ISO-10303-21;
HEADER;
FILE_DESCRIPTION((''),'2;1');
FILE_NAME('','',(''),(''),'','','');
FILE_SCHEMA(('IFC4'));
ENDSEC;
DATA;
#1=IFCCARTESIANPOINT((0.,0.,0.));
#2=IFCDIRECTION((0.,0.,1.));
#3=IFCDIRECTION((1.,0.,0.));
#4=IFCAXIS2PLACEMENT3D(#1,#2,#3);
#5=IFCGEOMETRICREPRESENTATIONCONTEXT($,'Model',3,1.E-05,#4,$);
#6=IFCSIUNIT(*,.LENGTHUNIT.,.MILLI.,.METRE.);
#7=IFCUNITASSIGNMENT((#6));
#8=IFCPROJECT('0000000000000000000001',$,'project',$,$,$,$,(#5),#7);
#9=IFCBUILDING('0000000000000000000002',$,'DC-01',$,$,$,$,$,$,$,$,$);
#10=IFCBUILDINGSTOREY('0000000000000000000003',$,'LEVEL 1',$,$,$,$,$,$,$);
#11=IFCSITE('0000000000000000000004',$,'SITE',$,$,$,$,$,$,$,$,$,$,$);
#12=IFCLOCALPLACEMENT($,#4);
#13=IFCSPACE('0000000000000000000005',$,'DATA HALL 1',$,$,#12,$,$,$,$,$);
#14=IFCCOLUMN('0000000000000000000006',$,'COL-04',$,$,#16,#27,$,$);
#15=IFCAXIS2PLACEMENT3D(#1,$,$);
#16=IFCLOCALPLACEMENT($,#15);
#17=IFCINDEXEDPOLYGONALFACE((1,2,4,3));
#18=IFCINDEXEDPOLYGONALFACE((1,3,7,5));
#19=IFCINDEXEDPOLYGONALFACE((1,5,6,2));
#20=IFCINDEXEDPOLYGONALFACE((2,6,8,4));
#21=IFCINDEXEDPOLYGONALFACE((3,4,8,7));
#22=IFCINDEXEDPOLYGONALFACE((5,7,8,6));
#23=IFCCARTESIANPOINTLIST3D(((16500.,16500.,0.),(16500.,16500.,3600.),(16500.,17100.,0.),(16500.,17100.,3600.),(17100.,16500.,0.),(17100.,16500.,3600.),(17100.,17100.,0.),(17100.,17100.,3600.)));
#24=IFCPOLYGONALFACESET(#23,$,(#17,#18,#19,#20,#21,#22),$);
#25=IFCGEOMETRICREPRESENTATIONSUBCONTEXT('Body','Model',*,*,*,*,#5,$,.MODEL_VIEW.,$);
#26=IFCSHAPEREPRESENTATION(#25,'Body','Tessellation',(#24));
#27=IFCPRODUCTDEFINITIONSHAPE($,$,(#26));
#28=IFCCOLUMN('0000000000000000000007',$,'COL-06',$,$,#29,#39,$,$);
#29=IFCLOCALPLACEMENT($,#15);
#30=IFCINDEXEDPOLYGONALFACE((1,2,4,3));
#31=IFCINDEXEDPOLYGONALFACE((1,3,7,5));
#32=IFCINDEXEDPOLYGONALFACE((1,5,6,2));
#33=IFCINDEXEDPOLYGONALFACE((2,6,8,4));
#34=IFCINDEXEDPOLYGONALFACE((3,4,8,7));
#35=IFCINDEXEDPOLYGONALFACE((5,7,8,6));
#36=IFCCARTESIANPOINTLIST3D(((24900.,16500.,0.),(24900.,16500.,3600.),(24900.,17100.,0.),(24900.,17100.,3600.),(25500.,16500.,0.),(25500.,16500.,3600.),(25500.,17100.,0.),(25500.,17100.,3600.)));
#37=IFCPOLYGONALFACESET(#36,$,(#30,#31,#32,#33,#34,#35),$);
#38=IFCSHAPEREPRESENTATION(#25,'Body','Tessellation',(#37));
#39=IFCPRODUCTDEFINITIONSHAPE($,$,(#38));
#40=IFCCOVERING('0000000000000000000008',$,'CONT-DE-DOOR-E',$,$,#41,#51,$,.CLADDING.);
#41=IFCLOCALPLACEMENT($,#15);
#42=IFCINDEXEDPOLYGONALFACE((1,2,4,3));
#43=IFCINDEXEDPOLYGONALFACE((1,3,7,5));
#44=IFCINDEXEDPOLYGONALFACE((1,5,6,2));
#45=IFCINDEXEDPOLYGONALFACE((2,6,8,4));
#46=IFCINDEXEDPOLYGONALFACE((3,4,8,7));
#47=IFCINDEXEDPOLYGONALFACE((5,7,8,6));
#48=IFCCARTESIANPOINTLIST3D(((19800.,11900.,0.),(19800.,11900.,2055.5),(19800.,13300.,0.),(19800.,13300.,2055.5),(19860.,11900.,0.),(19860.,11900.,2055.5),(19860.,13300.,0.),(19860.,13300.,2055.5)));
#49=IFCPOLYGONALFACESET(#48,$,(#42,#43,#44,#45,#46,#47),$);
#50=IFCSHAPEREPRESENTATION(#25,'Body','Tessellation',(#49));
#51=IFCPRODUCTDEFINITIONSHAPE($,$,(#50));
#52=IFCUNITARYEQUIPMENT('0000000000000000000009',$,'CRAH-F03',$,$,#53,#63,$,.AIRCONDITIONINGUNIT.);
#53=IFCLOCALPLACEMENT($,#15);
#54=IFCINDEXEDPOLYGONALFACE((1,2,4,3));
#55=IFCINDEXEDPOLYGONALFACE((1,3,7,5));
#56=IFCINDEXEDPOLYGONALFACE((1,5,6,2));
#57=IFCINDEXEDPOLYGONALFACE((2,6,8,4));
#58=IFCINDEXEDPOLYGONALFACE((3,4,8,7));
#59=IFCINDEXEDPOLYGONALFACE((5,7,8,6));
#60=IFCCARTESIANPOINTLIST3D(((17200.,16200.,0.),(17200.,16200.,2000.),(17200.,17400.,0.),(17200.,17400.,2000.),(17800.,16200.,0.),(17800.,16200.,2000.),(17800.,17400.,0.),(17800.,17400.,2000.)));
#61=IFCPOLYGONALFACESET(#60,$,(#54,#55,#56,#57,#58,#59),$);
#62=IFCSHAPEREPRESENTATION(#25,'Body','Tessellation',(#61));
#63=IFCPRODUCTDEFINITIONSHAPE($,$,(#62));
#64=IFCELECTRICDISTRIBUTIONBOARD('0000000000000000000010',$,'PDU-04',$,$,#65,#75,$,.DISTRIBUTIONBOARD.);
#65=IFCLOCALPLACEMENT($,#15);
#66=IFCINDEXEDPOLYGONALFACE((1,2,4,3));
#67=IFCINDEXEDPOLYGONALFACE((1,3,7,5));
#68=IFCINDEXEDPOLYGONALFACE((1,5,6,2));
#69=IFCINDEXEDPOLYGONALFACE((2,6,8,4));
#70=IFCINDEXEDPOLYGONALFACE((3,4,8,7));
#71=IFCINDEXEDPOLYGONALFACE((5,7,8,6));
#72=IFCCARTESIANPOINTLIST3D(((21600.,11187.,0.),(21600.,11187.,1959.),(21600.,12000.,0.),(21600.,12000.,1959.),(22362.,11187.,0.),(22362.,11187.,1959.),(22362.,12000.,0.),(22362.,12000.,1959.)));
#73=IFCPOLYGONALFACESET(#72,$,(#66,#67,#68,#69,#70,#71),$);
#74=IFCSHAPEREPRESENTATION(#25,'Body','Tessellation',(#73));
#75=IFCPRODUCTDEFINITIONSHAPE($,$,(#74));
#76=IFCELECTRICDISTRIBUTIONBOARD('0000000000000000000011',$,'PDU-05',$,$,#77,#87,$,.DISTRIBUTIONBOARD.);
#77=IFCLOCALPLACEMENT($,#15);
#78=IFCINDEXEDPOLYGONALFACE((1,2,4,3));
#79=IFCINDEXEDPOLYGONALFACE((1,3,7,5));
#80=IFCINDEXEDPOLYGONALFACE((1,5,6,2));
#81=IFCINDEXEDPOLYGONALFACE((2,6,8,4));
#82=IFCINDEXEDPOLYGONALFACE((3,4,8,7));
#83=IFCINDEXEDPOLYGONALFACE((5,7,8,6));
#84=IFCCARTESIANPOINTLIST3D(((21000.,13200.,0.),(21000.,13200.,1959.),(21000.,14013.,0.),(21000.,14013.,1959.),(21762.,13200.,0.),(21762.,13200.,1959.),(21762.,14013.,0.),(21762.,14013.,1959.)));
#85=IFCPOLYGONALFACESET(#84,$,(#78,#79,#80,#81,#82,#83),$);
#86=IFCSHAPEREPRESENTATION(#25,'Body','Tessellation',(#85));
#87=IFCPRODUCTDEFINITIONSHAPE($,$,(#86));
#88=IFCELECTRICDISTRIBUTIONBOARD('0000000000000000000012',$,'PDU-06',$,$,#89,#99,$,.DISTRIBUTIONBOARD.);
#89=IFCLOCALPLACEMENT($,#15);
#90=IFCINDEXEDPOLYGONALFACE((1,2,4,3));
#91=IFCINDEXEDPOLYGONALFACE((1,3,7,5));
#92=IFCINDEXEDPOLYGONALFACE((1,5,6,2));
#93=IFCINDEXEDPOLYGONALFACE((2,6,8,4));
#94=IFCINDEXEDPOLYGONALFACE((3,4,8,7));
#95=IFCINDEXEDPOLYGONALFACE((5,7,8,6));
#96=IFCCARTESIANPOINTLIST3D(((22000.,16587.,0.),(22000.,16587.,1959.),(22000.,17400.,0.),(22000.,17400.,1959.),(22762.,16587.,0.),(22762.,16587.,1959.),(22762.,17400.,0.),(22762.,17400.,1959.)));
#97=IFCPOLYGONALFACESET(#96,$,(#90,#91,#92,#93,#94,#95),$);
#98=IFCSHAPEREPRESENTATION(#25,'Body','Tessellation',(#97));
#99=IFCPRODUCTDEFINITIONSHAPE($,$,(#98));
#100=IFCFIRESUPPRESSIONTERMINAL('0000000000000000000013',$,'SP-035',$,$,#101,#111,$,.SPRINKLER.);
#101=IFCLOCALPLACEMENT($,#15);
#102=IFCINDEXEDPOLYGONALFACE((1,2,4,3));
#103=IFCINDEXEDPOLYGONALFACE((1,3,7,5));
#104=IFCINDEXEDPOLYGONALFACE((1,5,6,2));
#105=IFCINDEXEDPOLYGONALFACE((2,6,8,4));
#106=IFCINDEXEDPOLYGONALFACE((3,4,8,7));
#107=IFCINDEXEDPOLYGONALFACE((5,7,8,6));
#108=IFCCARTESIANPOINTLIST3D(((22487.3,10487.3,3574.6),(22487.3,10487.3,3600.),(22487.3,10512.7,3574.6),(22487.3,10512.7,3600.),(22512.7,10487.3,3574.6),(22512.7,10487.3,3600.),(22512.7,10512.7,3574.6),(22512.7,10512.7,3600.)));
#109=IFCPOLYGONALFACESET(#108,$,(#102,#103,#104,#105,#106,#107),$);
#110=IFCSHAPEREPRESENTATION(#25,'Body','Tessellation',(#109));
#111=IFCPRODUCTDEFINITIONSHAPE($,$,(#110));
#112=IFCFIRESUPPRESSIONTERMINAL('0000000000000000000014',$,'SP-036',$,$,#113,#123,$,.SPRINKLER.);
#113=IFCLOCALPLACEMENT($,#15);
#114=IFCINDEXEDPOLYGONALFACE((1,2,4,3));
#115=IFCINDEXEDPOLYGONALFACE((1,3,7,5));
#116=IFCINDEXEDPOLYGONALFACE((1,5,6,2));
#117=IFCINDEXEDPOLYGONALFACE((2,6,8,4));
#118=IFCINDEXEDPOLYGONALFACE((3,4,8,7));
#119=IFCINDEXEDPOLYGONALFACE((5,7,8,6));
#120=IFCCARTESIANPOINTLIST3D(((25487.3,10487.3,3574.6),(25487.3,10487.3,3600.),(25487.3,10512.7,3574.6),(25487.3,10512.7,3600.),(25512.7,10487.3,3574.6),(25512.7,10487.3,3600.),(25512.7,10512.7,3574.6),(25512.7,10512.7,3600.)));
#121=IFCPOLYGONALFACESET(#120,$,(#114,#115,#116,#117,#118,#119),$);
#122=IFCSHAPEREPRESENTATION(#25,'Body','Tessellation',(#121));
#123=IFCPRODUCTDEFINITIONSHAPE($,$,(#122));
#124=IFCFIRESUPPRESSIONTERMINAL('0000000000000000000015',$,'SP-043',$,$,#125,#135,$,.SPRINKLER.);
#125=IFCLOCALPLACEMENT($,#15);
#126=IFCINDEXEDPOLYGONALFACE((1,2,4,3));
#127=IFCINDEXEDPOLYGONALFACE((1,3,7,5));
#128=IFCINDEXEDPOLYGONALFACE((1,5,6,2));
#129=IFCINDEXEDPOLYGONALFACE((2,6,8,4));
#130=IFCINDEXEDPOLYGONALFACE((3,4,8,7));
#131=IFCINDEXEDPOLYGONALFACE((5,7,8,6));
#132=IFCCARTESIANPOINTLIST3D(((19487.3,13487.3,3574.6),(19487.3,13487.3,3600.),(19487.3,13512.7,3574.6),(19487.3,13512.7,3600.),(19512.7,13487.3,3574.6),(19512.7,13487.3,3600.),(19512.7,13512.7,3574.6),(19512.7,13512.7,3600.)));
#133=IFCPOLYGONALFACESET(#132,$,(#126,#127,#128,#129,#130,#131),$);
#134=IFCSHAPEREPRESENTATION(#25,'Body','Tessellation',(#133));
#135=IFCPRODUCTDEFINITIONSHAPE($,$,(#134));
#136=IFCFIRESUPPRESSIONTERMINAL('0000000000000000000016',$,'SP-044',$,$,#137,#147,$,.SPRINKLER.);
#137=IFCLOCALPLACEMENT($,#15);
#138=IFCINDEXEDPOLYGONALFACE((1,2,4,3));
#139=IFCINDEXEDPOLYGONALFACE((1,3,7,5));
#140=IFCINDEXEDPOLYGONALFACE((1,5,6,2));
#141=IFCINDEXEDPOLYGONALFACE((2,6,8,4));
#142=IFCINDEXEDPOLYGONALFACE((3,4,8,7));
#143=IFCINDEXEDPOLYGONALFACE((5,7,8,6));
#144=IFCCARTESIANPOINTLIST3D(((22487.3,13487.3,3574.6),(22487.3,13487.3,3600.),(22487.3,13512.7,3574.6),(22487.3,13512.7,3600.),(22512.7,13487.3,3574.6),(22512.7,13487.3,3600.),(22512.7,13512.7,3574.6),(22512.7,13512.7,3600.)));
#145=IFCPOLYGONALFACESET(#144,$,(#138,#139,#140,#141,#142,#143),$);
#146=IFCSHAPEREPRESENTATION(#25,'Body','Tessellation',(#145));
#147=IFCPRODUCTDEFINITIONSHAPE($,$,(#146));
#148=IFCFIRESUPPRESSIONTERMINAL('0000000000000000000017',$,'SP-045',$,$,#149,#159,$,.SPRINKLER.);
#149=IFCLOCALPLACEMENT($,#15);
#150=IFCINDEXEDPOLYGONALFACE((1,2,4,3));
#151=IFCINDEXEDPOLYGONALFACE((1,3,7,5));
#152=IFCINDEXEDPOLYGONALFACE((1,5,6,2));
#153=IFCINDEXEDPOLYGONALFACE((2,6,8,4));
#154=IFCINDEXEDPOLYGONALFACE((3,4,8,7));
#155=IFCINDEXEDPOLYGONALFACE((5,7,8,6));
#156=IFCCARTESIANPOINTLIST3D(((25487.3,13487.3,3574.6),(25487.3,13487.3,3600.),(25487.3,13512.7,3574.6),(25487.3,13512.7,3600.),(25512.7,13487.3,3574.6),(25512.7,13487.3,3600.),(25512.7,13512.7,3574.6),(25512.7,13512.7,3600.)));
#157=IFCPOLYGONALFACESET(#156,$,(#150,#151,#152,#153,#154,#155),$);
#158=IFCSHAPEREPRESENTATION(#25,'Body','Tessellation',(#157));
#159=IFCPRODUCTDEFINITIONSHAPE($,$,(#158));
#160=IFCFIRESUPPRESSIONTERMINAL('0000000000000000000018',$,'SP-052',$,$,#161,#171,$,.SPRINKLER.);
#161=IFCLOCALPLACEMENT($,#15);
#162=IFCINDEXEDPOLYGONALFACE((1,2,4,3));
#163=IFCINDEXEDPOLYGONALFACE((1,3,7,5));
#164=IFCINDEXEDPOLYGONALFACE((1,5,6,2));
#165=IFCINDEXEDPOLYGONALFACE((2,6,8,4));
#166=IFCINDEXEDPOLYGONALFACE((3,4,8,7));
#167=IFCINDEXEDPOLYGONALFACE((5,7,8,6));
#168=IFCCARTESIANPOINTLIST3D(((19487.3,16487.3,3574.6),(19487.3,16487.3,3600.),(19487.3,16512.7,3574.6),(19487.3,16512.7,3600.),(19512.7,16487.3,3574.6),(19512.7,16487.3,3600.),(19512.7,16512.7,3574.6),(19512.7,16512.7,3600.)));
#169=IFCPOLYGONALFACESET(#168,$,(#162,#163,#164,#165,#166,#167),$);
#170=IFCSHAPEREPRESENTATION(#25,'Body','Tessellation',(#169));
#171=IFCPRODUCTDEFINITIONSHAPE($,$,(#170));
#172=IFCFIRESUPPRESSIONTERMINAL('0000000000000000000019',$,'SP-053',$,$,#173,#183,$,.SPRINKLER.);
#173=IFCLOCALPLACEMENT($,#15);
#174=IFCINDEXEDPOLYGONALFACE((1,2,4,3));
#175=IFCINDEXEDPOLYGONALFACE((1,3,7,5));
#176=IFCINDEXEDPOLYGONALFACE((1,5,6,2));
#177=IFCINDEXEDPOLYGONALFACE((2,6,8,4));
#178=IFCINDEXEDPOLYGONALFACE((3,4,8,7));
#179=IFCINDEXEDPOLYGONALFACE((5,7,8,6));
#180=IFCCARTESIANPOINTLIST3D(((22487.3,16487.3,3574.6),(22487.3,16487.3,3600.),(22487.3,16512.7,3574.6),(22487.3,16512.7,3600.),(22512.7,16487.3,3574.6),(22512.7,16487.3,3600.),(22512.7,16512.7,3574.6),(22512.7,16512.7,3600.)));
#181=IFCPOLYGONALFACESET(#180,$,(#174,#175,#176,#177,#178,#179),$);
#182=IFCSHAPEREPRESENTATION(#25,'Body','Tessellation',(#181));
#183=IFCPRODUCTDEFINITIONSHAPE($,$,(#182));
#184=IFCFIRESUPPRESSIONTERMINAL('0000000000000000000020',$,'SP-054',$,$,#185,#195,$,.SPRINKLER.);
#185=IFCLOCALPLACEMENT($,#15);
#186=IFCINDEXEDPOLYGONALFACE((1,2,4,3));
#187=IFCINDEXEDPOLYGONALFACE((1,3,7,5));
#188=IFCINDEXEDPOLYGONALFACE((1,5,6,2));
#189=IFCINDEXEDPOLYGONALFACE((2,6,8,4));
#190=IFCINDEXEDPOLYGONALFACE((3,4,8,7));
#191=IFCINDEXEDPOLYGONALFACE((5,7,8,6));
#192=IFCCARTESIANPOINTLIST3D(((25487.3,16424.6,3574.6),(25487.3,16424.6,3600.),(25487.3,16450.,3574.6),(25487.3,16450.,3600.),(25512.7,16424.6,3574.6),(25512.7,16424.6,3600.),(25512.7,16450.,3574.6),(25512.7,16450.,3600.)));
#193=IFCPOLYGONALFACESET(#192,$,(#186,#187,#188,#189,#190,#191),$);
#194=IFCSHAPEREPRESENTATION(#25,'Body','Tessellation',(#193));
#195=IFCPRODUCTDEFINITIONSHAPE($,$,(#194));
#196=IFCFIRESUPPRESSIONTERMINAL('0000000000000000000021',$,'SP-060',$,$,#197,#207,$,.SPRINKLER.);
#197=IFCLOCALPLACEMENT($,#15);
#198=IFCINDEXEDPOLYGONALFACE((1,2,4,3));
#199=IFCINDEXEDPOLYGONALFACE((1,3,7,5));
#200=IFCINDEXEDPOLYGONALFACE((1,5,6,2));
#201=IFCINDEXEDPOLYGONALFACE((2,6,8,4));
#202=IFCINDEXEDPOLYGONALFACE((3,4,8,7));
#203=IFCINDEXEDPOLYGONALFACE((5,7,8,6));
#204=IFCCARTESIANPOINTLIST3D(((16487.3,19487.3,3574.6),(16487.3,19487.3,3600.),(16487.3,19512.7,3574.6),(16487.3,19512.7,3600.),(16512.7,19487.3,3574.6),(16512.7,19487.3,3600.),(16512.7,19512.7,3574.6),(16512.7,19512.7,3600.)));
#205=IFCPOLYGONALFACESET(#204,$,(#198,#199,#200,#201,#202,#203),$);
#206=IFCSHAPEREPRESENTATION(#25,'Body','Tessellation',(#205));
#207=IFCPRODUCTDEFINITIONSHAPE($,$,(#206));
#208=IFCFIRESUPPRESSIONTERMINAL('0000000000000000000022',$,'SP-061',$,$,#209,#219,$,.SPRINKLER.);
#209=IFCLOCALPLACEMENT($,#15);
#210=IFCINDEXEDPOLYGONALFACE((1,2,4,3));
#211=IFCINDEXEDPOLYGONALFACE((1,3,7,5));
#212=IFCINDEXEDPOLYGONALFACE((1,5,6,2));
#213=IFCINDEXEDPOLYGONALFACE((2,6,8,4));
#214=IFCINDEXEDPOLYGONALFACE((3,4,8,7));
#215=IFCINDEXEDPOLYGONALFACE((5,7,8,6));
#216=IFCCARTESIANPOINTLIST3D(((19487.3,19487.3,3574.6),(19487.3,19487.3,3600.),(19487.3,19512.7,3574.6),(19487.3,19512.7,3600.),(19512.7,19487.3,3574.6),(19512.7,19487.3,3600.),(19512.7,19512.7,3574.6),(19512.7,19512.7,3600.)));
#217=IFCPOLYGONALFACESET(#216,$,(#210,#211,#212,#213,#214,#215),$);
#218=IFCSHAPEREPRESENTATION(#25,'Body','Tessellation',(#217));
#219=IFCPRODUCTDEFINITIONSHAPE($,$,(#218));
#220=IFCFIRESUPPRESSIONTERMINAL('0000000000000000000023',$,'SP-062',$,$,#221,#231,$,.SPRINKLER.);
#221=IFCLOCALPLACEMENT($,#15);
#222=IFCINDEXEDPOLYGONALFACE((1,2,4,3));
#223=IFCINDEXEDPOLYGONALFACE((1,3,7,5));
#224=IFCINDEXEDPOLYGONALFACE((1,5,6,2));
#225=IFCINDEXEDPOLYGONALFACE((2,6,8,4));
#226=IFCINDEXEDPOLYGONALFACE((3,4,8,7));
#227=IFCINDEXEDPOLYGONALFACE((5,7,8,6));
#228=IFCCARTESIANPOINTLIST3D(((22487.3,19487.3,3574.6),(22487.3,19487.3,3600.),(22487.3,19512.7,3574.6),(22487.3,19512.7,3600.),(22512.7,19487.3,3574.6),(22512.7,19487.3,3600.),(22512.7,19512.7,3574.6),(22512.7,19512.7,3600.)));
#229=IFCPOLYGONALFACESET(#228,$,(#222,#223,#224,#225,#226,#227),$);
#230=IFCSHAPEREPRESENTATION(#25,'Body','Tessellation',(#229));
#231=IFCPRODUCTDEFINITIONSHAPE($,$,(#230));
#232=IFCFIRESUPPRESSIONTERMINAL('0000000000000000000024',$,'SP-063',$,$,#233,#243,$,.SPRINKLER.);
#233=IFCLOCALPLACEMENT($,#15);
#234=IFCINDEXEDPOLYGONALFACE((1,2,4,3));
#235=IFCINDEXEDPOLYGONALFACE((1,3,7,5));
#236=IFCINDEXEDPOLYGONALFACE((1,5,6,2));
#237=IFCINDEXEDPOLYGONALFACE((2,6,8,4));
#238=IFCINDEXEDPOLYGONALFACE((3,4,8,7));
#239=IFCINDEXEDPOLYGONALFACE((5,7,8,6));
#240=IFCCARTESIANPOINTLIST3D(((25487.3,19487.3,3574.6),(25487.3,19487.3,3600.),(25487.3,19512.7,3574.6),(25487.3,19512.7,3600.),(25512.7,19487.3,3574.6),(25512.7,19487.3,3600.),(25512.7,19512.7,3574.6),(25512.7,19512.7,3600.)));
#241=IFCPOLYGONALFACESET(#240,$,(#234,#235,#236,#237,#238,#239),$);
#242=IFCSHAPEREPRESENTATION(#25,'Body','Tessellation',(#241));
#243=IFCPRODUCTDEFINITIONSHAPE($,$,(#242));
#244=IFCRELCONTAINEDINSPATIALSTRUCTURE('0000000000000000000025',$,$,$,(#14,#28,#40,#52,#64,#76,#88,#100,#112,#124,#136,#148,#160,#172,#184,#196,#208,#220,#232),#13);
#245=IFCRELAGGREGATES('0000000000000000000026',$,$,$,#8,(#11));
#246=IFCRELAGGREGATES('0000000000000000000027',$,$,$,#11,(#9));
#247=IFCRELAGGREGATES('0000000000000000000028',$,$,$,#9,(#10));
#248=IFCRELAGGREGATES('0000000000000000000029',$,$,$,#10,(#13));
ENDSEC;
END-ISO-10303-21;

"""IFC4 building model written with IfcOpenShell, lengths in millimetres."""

from ifc_helpers import new_model, si_unit, frame, origin, origin_with_axes, place, context, subcontext, project, spatial, polyline, outline, extrude, element, save


model = new_model("IFC4")

# Units and contexts
model_context = context("Model", 3, precision=1e-05, world=origin_with_axes())
body_context = subcontext(model_context, "Body", "Model", "MODEL_VIEW")
ifc_project = project(units=[si_unit("LENGTHUNIT", "METRE", prefix="MILLI")], contexts=[model_context])

# Site, building, storey, space
site = spatial("IfcSite", under=ifc_project, Name="SITE")
building = spatial("IfcBuilding", under=site, Name="DC-01")
storey = spatial("IfcBuildingStorey", under=building, Name="LEVEL 1")
space_placement = place(None, origin_with_axes())
space = spatial("IfcSpace", under=storey, at=space_placement, Name="DATA HALL 1")

# Columns
for number, where, z_axis, x_axis, name in (
    (1, (16500.0, 16500.0, 0.0), (0.0, 0.0, 1.0), (1.0, 0.0, 0.0), "COL-04"),
    (2, (24900.0, 16500.0, 0.0), (0.0, 0.0, 1.0), (1.0, 0.0, 0.0), "COL-06"),
):
    element("IfcColumn", number, at=place(space_placement, frame(where, z_axis=z_axis, x_axis=x_axis)), inside=space, Name=name, context=body_context, shape_type="SweptSolid", body=[
        extrude(outline(polyline([(0.0, 0.0), (600.0, 0.0), (600.0, 600.0), (0.0, 600.0), (0.0, 0.0)])), origin(), (0.0, 0.0, 1.0), 3600.0),
    ])

# Covering
covering_placement = place(space_placement, frame((19800.0, 11900.0, 0.0), z_axis=(0.0, 0.0, 1.0), x_axis=(1.0, 0.0, 0.0)))
element("IfcCovering", 3, at=covering_placement, inside=space, Name="CONT-DE-DOOR-E", PredefinedType="CLADDING", context=body_context, shape_type="SweptSolid", body=[
    extrude(outline(polyline([(0.0, 0.0), (60.0, 0.0), (60.0, 1400.0), (0.0, 1400.0), (0.0, 0.0)])), origin(), (0.0, 0.0, 1.0), 2055.5),
])

# Unitary equipment
unitary_equipment_placement = place(space_placement, frame((17200.0, 16200.0, 0.0), z_axis=(0.0, 0.0, 1.0), x_axis=(1.0, 0.0, 0.0)))
element("IfcUnitaryEquipment", 4, at=unitary_equipment_placement, inside=space, Name="CRAH-F03", PredefinedType="AIRCONDITIONINGUNIT", context=body_context, shape_type="SweptSolid", body=[
    extrude(outline(polyline([(0.0, 0.0), (600.0, 0.0), (600.0, 1200.0), (0.0, 1200.0), (0.0, 0.0)])), origin(), (0.0, 0.0, 1.0), 2000.0),
])

# Electric distribution boards
for number, where, z_axis, x_axis, name in (
    (5, (21600.0, 11187.0, 0.0), (0.0, 0.0, 1.0), (1.0, 0.0, 0.0), "PDU-04"),
    (6, (21762.0, 14013.0, 0.0), (0.0, 0.0, 1.0), (-1.0, 0.0, 0.0), "PDU-05"),
    (7, (22000.0, 16587.0, 0.0), (0.0, 0.0, 1.0), (1.0, 0.0, 0.0), "PDU-06"),
):
    element("IfcElectricDistributionBoard", number, at=place(space_placement, frame(where, z_axis=z_axis, x_axis=x_axis)), inside=space, Name=name, PredefinedType="DISTRIBUTIONBOARD", context=body_context, shape_type="SweptSolid", body=[
        extrude(outline(polyline([(0.0, 0.0), (762.0, 0.0), (762.0, 813.0), (0.0, 813.0), (0.0, 0.0)])), origin(), (0.0, 0.0, 1.0), 1959.0),
    ])

# Fire suppression terminals
for number, where, z_axis, x_axis, name in (
    (8, (22487.3, 10487.3, 3574.6), (0.0, 0.0, 1.0), (1.0, 0.0, 0.0), "SP-035"),
    (9, (25487.3, 10487.3, 3574.6), (0.0, 0.0, 1.0), (1.0, 0.0, 0.0), "SP-036"),
    (10, (19487.3, 13487.3, 3574.6), (0.0, 0.0, 1.0), (1.0, 0.0, 0.0), "SP-043"),
    (11, (22487.3, 13487.3, 3574.6), (0.0, 0.0, 1.0), (1.0, 0.0, 0.0), "SP-044"),
    (12, (25487.3, 13487.3, 3574.6), (0.0, 0.0, 1.0), (1.0, 0.0, 0.0), "SP-045"),
    (13, (19487.3, 16487.3, 3574.6), (0.0, 0.0, 1.0), (1.0, 0.0, 0.0), "SP-052"),
    (14, (22487.3, 16487.3, 3574.6), (0.0, 0.0, 1.0), (1.0, 0.0, 0.0), "SP-053"),
    (15, (25487.3, 16424.6, 3574.6), (0.0, 0.0, 1.0), (1.0, 0.0, 0.0), "SP-054"),
    (16, (16487.3, 19487.3, 3574.6), (0.0, 0.0, 1.0), (1.0, 0.0, 0.0), "SP-060"),
    (17, (19487.3, 19487.3, 3574.6), (0.0, 0.0, 1.0), (1.0, 0.0, 0.0), "SP-061"),
    (18, (22487.3, 19487.3, 3574.6), (0.0, 0.0, 1.0), (1.0, 0.0, 0.0), "SP-062"),
    (19, (25487.3, 19487.3, 3574.6), (0.0, 0.0, 1.0), (1.0, 0.0, 0.0), "SP-063"),
):
    element("IfcFireSuppressionTerminal", number, at=place(space_placement, frame(where, z_axis=z_axis, x_axis=x_axis)), inside=space, Name=name, PredefinedType="SPRINKLER", context=body_context, shape_type="SweptSolid", body=[
        extrude(outline(polyline([(0.0, 0.0), (25.4, 0.0), (25.4, 25.4), (0.0, 25.4), (0.0, 0.0)])), origin(), (0.0, 0.0, 1.0), 25.4),
    ])

save(model, "model.ifc")
